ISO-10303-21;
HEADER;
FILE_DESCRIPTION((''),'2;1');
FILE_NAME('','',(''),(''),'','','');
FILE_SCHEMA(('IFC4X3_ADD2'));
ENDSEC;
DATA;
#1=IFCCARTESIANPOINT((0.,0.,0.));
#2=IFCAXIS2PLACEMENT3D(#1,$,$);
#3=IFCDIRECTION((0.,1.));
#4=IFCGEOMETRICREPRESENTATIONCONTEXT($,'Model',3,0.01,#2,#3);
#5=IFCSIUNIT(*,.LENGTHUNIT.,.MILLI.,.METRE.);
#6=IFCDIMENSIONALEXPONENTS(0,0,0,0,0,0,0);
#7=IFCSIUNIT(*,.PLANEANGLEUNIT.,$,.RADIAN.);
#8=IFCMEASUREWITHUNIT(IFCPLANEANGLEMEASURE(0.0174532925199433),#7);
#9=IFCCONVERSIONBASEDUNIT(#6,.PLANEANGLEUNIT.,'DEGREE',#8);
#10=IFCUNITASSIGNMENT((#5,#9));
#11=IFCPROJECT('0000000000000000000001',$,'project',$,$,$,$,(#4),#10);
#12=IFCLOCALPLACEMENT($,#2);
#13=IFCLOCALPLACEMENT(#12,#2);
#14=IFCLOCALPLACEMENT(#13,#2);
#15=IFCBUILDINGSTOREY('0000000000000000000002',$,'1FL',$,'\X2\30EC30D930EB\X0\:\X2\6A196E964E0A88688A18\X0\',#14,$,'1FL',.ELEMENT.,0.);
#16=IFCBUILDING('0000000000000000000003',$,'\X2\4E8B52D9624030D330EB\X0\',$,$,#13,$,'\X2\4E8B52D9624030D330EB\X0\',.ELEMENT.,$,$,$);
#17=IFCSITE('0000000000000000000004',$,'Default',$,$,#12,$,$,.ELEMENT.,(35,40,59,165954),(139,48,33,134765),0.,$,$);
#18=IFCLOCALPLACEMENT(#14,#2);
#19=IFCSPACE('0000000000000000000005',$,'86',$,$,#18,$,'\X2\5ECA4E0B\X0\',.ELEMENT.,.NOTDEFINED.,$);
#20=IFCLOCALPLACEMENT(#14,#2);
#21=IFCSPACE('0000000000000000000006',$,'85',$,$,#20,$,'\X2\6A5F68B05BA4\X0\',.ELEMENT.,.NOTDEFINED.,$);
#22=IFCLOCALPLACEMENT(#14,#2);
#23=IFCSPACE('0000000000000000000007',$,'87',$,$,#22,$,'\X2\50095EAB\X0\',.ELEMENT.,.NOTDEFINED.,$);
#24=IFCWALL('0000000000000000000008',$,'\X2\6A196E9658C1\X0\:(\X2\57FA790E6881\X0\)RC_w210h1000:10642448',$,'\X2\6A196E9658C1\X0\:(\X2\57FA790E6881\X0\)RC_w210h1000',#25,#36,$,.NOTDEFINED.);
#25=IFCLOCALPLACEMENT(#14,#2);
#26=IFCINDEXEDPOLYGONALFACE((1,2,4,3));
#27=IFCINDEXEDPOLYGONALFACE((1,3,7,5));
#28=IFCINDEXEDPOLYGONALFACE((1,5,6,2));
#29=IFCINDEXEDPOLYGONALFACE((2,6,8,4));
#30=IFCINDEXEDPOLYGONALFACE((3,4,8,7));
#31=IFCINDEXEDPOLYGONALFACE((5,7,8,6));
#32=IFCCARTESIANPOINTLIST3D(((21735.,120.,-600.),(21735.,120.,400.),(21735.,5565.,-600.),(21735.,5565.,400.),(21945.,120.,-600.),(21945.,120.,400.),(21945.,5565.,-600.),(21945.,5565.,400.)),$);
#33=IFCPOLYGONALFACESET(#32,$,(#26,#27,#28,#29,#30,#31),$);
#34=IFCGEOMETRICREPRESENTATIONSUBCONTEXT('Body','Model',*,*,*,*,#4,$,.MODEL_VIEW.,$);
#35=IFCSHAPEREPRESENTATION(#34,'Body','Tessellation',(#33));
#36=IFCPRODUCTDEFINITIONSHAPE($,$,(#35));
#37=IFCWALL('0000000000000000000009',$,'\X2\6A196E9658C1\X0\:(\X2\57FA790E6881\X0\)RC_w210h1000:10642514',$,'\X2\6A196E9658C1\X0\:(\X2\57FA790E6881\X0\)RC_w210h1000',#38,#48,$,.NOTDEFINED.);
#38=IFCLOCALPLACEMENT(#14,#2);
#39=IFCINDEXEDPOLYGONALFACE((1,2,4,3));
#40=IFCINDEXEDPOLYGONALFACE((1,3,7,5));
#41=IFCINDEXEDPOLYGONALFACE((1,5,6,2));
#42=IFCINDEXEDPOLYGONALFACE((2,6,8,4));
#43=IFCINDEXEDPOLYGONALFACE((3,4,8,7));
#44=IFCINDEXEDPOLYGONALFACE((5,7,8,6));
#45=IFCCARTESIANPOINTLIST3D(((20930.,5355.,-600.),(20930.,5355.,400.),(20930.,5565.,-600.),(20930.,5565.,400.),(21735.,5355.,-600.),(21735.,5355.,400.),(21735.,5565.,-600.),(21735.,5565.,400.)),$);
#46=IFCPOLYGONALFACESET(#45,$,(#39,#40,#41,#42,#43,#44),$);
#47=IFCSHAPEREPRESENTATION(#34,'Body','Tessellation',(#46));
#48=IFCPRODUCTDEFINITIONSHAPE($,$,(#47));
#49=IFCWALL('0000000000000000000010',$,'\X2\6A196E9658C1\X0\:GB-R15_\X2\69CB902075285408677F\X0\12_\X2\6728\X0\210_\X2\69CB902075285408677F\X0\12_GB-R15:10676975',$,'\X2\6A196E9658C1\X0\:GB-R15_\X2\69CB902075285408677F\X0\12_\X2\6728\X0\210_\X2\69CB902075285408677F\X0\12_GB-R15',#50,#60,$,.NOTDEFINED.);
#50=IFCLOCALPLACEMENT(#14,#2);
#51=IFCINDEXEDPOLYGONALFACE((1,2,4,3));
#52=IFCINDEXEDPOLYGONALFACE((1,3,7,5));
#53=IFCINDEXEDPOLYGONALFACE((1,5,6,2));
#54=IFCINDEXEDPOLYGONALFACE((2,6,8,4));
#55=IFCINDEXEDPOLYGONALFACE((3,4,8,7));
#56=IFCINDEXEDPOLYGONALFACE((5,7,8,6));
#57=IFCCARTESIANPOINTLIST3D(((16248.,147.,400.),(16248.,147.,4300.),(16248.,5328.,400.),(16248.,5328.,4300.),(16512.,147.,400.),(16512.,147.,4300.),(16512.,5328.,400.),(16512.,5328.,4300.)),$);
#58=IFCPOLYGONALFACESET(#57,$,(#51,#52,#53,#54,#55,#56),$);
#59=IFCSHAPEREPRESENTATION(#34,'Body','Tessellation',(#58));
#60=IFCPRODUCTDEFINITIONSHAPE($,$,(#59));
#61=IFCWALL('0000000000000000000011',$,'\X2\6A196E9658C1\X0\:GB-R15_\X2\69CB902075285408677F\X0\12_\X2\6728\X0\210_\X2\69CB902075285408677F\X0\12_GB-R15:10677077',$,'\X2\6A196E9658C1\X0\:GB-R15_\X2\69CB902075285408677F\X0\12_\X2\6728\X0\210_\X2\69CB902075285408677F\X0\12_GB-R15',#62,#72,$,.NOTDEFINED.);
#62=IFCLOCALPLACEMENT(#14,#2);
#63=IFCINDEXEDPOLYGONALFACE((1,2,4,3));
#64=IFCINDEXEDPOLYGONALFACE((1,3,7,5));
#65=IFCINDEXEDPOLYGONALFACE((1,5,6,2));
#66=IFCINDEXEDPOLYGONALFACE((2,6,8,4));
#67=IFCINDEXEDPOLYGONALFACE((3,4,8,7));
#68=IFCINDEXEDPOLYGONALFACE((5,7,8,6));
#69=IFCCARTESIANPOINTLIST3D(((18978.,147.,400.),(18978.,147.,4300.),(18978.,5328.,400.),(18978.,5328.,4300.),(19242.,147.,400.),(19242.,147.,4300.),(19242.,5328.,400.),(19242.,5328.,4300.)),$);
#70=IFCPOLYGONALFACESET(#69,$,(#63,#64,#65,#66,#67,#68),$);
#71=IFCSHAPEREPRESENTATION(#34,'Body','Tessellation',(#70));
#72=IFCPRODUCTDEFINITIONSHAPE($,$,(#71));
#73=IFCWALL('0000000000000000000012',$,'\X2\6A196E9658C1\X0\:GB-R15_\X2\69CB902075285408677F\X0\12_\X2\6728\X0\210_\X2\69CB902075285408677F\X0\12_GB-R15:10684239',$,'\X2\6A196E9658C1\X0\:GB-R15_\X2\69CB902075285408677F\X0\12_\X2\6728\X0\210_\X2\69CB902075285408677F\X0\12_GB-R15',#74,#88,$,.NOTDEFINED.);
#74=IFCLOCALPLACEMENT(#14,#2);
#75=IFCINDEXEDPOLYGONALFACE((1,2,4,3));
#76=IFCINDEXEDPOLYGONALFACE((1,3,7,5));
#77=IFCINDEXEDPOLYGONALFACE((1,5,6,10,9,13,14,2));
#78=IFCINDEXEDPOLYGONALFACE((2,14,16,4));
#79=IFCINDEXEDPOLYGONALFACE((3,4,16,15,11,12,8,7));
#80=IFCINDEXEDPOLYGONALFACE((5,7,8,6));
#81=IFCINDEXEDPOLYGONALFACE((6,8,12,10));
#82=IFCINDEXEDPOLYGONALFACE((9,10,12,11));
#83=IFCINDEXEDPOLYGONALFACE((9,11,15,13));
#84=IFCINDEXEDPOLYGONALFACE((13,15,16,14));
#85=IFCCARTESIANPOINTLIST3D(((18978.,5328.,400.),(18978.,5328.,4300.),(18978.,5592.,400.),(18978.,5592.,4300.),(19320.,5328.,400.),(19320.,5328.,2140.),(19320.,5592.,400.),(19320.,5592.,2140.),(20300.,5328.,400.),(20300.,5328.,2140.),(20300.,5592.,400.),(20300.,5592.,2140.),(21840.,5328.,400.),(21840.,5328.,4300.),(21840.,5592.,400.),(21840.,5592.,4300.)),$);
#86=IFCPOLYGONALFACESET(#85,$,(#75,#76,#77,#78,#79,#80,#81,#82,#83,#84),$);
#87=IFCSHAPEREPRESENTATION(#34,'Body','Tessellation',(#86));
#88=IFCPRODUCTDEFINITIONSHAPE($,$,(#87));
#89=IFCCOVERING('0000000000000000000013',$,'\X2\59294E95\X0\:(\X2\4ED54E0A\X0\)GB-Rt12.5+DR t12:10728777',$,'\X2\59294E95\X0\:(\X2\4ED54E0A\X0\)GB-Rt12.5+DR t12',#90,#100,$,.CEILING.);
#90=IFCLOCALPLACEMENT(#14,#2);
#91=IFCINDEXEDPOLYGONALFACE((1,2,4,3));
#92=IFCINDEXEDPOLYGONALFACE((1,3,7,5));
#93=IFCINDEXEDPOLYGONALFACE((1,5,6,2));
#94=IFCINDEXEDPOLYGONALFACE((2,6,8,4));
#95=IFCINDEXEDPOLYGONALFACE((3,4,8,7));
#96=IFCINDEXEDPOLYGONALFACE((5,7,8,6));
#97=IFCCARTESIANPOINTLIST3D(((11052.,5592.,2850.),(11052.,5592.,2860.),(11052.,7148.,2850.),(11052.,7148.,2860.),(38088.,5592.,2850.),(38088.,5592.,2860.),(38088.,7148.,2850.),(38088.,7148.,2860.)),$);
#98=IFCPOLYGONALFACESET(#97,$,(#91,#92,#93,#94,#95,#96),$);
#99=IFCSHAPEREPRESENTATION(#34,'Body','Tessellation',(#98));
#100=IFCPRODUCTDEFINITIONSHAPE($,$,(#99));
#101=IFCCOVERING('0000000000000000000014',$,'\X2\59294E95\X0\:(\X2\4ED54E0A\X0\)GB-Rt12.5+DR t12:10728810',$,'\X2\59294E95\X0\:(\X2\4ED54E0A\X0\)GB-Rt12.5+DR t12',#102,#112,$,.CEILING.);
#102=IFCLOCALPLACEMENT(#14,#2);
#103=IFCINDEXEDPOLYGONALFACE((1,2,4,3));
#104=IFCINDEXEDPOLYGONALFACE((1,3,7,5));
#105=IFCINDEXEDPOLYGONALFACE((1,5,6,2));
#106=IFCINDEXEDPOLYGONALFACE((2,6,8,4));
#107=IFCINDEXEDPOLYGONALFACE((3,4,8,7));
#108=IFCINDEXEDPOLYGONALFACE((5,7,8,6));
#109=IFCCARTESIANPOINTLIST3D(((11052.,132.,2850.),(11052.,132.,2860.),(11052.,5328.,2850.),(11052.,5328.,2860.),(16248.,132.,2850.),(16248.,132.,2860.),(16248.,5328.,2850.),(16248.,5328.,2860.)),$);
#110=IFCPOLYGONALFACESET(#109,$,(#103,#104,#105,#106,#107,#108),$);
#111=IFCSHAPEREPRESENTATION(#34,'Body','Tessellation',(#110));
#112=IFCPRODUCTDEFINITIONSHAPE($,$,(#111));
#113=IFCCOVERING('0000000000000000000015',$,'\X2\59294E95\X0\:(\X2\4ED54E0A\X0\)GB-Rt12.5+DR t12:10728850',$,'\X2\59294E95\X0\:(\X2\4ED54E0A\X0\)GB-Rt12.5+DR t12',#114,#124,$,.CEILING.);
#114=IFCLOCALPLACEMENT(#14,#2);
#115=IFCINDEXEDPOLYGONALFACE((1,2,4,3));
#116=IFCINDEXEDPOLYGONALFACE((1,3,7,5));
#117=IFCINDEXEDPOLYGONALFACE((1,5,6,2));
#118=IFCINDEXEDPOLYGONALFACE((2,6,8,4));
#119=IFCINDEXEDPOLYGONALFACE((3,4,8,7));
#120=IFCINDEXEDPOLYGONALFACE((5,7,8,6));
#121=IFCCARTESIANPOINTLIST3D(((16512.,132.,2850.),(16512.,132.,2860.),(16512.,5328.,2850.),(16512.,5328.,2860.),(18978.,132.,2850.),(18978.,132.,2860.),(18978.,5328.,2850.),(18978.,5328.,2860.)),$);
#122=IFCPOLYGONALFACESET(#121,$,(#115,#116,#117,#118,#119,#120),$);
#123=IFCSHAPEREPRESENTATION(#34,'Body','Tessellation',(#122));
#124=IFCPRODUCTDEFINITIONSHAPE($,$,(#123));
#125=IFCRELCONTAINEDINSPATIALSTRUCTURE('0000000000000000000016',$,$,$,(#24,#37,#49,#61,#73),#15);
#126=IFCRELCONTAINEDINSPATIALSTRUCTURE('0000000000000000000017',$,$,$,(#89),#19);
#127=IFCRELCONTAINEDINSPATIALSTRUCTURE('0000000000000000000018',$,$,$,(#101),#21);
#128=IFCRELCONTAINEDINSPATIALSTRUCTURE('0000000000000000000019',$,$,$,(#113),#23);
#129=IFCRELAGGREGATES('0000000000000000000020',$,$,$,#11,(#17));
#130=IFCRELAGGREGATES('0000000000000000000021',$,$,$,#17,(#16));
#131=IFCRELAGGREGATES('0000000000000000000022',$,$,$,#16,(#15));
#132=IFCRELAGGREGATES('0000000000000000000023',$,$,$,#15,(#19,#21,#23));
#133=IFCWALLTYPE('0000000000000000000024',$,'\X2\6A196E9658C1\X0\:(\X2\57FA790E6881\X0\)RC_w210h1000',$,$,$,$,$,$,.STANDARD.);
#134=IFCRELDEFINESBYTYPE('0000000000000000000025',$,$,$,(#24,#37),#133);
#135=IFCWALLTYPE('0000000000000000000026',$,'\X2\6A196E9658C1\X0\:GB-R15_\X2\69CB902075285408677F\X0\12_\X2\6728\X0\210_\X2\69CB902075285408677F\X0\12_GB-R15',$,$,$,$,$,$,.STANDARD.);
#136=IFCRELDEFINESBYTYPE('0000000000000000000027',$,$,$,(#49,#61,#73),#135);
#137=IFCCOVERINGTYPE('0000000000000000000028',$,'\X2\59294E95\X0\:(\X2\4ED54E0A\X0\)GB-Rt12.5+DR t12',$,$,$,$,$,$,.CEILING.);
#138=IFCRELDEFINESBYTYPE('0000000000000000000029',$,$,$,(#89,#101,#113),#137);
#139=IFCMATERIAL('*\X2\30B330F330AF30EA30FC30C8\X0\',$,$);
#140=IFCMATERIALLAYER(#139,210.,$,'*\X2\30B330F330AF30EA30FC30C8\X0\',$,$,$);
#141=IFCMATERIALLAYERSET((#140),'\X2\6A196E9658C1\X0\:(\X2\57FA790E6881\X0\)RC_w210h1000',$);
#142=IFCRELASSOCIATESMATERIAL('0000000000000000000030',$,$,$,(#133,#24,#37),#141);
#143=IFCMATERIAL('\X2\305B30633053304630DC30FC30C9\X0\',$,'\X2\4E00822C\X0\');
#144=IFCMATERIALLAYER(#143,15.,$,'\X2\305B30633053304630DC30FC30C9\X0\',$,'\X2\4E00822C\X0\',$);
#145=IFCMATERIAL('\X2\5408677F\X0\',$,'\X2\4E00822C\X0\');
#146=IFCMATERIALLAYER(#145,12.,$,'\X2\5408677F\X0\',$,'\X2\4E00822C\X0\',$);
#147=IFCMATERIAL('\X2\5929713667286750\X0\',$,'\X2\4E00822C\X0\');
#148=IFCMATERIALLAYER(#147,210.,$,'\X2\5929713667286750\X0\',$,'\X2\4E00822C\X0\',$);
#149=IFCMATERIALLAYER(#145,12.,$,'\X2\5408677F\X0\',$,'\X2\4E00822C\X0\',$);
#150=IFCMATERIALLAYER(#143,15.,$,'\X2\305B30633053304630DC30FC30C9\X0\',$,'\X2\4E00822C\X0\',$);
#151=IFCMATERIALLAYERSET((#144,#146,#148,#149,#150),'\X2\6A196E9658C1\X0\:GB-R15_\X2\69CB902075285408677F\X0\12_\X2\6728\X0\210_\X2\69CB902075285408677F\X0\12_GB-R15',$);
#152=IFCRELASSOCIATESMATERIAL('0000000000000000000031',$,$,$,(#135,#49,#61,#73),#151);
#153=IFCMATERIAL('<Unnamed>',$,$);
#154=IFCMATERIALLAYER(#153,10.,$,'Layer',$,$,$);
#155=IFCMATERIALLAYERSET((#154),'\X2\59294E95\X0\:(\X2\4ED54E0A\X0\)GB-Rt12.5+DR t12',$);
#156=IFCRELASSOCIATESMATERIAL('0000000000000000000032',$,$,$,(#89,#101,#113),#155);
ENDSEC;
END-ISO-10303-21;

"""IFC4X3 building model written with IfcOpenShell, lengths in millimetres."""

from ifc_helpers import new_model, entity, si_unit, converted_unit, direction, frame, frame_2d, origin, place, context, subcontext, project, spatial, rectangle, extrude, material, layer, layer_set, layer_usage, type_object, element, save


model = new_model("IFC4X3")

# Units and contexts
model_context = context("Model", 3, precision=0.01, world=origin(), true_north=direction((0.0, 1.0)))
body_context = subcontext(model_context, "Body", "Model", "MODEL_VIEW")
ifc_project = project(units=[si_unit("LENGTHUNIT", "METRE", prefix="MILLI"), converted_unit("PLANEANGLEUNIT", "DEGREE", entity("IfcPlaneAngleMeasure", 0.0174532925199433), si_unit("PLANEANGLEUNIT", "RADIAN"), dimensions=[0, 0, 0, 0, 0, 0, 0])], contexts=[model_context])

# Site, building, storey
site_placement = place(None, origin())
site = spatial("IfcSite", under=ifc_project, at=site_placement, Name="Default", CompositionType="ELEMENT", RefLatitude=(35, 40, 59, 165954), RefLongitude=(139, 48, 33, 134765), RefElevation=0.0)
building_placement = place(site_placement, origin())
building = spatial("IfcBuilding", under=site, at=building_placement, Name="事務所ビル", LongName="事務所ビル", CompositionType="ELEMENT")
storey_placement = place(building_placement, origin())
storey = spatial("IfcBuildingStorey", under=building, at=storey_placement, Name="1FL", ObjectType="レベル:標準上表記", LongName="1FL", CompositionType="ELEMENT", Elevation=0.0)

# Shared definitions
ifc_material_1 = material(Name="*コンクリート")

# Walls
ifc_layer_1 = layer(ifc_material_1, 210.0, Name="*コンクリート")
ifc_layer_set_1 = layer_set([ifc_layer_1], Name="標準壁:(基礎梁)RC_w210h1000")
wall_type_1 = type_object("IfcWallType", Name="標準壁:(基礎梁)RC_w210h1000", PredefinedType="STANDARD", material=ifc_layer_set_1)
wall_1_placement = place(storey_placement, frame((21840.0, 120.0, -600.0), z_axis=(0.0, 0.0, 1.0), x_axis=(0.0, 1.0, 0.0)))
element("IfcWall", 1, at=wall_1_placement, inside=storey, type_object=wall_type_1, material=ifc_layer_set_1, Name="標準壁:(基礎梁)RC_w210h1000:10642448", ObjectType="標準壁:(基礎梁)RC_w210h1000", PredefinedType="NOTDEFINED", context=body_context, shape_type="SweptSolid", body=[
    extrude(rectangle(XDim=5445.0, YDim=210.0, at=frame_2d((2722.5, 0.0), x_axis=(-1.0, 0.0))), origin(), (0.0, 0.0, 1.0), 1000.0),
])
wall_2_placement = place(storey_placement, frame((21735.0, 5460.0, -600.0), z_axis=(0.0, 0.0, 1.0), x_axis=(-1.0, 0.0, 0.0)))
element("IfcWall", 2, at=wall_2_placement, inside=storey, type_object=wall_type_1, material=ifc_layer_set_1, Name="標準壁:(基礎梁)RC_w210h1000:10642514", ObjectType="標準壁:(基礎梁)RC_w210h1000", PredefinedType="NOTDEFINED", context=body_context, shape_type="SweptSolid", body=[
    extrude(rectangle(XDim=805.0, YDim=210.0, at=frame_2d((402.5, 0.0), x_axis=(-1.0, 0.0))), origin(), (0.0, 0.0, 1.0), 1000.0),
])

# Shared definitions
ifc_material_2 = material(Name="せっこうボード", Category="一般")
ifc_layer_2 = layer(ifc_material_2, 15.0, Name="せっこうボード", Category="一般")
ifc_material_3 = material(Name="合板", Category="一般")
ifc_layer_3 = layer(ifc_material_3, 12.0, Name="合板", Category="一般")
ifc_material_4 = material(Name="天然木材", Category="一般")
ifc_layer_4 = layer(ifc_material_4, 210.0, Name="天然木材", Category="一般")
ifc_layer_5 = layer(ifc_material_3, 12.0, Name="合板", Category="一般")
ifc_layer_6 = layer(ifc_material_2, 15.0, Name="せっこうボード", Category="一般")
ifc_layer_set_2 = layer_set([ifc_layer_2, ifc_layer_3, ifc_layer_4, ifc_layer_5, ifc_layer_6], Name="標準壁:GB-R15_構造用合板12_木210_構造用合板12_GB-R15")
wall_type_2 = type_object("IfcWallType", Name="標準壁:GB-R15_構造用合板12_木210_構造用合板12_GB-R15", PredefinedType="STANDARD", material=ifc_layer_set_2)

# Walls
wall_3_placement = place(storey_placement, frame((16380.0, 147.0, 400.0), z_axis=(0.0, 0.0, 1.0), x_axis=(0.0, 1.0, 0.0)))
element("IfcWall", 3, at=wall_3_placement, inside=storey, type_object=wall_type_2, material=ifc_layer_set_2, Name="標準壁:GB-R15_構造用合板12_木210_構造用合板12_GB-R15:10676975", ObjectType="標準壁:GB-R15_構造用合板12_木210_構造用合板12_GB-R15", PredefinedType="NOTDEFINED", context=body_context, shape_type="SweptSolid", body=[
    extrude(rectangle(XDim=5181.0, YDim=264.0, at=frame_2d((2590.5, 0.0), x_axis=(-1.0, 0.0))), origin(), (0.0, 0.0, 1.0), 3900.0),
])
wall_4_placement = place(storey_placement, frame((19110.0, 147.0, 400.0), z_axis=(0.0, 0.0, 1.0), x_axis=(0.0, 1.0, 0.0)))
element("IfcWall", 4, at=wall_4_placement, inside=storey, type_object=wall_type_2, material=ifc_layer_set_2, Name="標準壁:GB-R15_構造用合板12_木210_構造用合板12_GB-R15:10677077", ObjectType="標準壁:GB-R15_構造用合板12_木210_構造用合板12_GB-R15", PredefinedType="NOTDEFINED", context=body_context, shape_type="SweptSolid", body=[
    extrude(rectangle(XDim=5181.0, YDim=264.0, at=frame_2d((2590.5, 0.0), x_axis=(-1.0, 0.0))), origin(), (0.0, 0.0, 1.0), 3900.0),
])

# Wall, openings
wall_5_placement = place(storey_placement, frame((18978.0, 5460.0, 400.0)))
wall_5 = element("IfcWall", 5, at=wall_5_placement, inside=storey, type_object=wall_type_2, material=ifc_layer_set_2, Name="標準壁:GB-R15_構造用合板12_木210_構造用合板12_GB-R15:10684239", ObjectType="標準壁:GB-R15_構造用合板12_木210_構造用合板12_GB-R15", PredefinedType="NOTDEFINED", context=body_context, shape_type="SweptSolid", body=[
    extrude(rectangle(XDim=2862.0, YDim=264.0, at=frame_2d((1431.0, 0.0), x_axis=(-1.0, 0.0))), origin(), (0.0, 0.0, 1.0), 3900.0),
])
opening_1_placement = place(wall_5_placement, frame((-18978.0, -5460.0, 3900.0)))
element("IfcOpeningElement", 6, at=opening_1_placement, cuts=wall_5, PredefinedType="OPENING", context=body_context, shape_type="SweptSolid", body=[
    extrude(rectangle(XDim=2140.0, YDim=980.0, at=frame_2d((0.0, 0.0), x_axis=(0.0, 1.0))), frame((19810.0, 3804.0, 1070.0), z_axis=(0.0, 1.0, 0.0), x_axis=(1.0, 0.0, 0.0)), (0.0, 0.0, 1.0), 3048.0),
])
opening_2_placement = place(wall_5_placement, frame((342.0, -132.0, -400.0)))
element("IfcOpeningElement", 7, at=opening_2_placement, cuts=wall_5, PredefinedType="OPENING", context=body_context, shape_type="SweptSolid", body=[
    extrude(rectangle(XDim=2140.0, YDim=980.0, at=frame_2d((1070.0, 490.0), x_axis=(-1.0, 0.0))), frame((0.0, 0.0, 0.0), z_axis=(0.0, 1.0, 0.0), x_axis=(0.0, 0.0, 1.0)), (0.0, 0.0, 1.0), 264.0),
])

# Shared definitions
space_1_placement = place(storey_placement, origin())
space_1 = spatial("IfcSpace", under=storey, at=space_1_placement, Name="86", LongName="廊下", CompositionType="ELEMENT", PredefinedType="NOTDEFINED")

# Covering
ifc_material_5 = material(Name="<Unnamed>")
ifc_layer_7 = layer(ifc_material_5, 10.0, Name="Layer")
ifc_layer_set_3 = layer_set([ifc_layer_7], Name="天井:(仕上)GB-Rt12.5+DR t12")
ifc_layer_usage_1 = layer_usage(ifc_layer_set_3, "AXIS3", "NEGATIVE", 0.0)
covering_type = type_object("IfcCoveringType", Name="天井:(仕上)GB-Rt12.5+DR t12", PredefinedType="CEILING")
covering_1_placement = place(space_1_placement, frame((11052.0, 5592.0, 2850.0)))
element("IfcCovering", 8, at=covering_1_placement, inside=space_1, type_object=covering_type, material=ifc_layer_usage_1, Name="天井:(仕上)GB-Rt12.5+DR t12:10728777", ObjectType="天井:(仕上)GB-Rt12.5+DR t12", PredefinedType="CEILING", context=body_context, shape_type="SweptSolid", body=[
    extrude(rectangle(XDim=1556.0, YDim=27036.0, at=frame_2d((0.0, 0.0), x_axis=(1.0, 0.0))), frame((13518.0, 778.0, 0.0), z_axis=(0.0, 0.0, 1.0), x_axis=(0.0, -1.0, 0.0)), (0.0, 0.0, 1.0), 10.0),
])

# Shared definitions
space_2_placement = place(storey_placement, origin())
space_2 = spatial("IfcSpace", under=storey, at=space_2_placement, Name="85", LongName="機械室", CompositionType="ELEMENT", PredefinedType="NOTDEFINED")

# Covering
ifc_layer_usage_2 = layer_usage(ifc_layer_set_3, "AXIS3", "NEGATIVE", 0.0)
covering_2_placement = place(space_2_placement, frame((11052.0, 132.0, 2850.0)))
element("IfcCovering", 9, at=covering_2_placement, inside=space_2, type_object=covering_type, material=ifc_layer_usage_2, Name="天井:(仕上)GB-Rt12.5+DR t12:10728810", ObjectType="天井:(仕上)GB-Rt12.5+DR t12", PredefinedType="CEILING", context=body_context, shape_type="SweptSolid", body=[
    extrude(rectangle(XDim=5196.0, YDim=5196.0, at=frame_2d((0.0, 0.0), x_axis=(1.0, 0.0))), frame((2598.0, 2598.0, 0.0), z_axis=(0.0, 0.0, 1.0), x_axis=(-1.0, 0.0, 0.0)), (0.0, 0.0, 1.0), 10.0),
])

# Shared definitions
space_3_placement = place(storey_placement, origin())
space_3 = spatial("IfcSpace", under=storey, at=space_3_placement, Name="87", LongName="倉庫", CompositionType="ELEMENT", PredefinedType="NOTDEFINED")

# Covering
ifc_layer_usage_3 = layer_usage(ifc_layer_set_3, "AXIS3", "NEGATIVE", 0.0)
covering_3_placement = place(space_3_placement, frame((16512.0, 132.0, 2850.0)))
element("IfcCovering", 10, at=covering_3_placement, inside=space_3, type_object=covering_type, material=ifc_layer_usage_3, Name="天井:(仕上)GB-Rt12.5+DR t12:10728850", ObjectType="天井:(仕上)GB-Rt12.5+DR t12", PredefinedType="CEILING", context=body_context, shape_type="SweptSolid", body=[
    extrude(rectangle(XDim=2466.0, YDim=5196.0, at=frame_2d((0.0, 0.0), x_axis=(1.0, 0.0))), frame((1233.0, 2598.0, 0.0), z_axis=(0.0, 0.0, 1.0), x_axis=(-1.0, 0.0, 0.0)), (0.0, 0.0, 1.0), 10.0),
])

save(model, "model.ifc")
